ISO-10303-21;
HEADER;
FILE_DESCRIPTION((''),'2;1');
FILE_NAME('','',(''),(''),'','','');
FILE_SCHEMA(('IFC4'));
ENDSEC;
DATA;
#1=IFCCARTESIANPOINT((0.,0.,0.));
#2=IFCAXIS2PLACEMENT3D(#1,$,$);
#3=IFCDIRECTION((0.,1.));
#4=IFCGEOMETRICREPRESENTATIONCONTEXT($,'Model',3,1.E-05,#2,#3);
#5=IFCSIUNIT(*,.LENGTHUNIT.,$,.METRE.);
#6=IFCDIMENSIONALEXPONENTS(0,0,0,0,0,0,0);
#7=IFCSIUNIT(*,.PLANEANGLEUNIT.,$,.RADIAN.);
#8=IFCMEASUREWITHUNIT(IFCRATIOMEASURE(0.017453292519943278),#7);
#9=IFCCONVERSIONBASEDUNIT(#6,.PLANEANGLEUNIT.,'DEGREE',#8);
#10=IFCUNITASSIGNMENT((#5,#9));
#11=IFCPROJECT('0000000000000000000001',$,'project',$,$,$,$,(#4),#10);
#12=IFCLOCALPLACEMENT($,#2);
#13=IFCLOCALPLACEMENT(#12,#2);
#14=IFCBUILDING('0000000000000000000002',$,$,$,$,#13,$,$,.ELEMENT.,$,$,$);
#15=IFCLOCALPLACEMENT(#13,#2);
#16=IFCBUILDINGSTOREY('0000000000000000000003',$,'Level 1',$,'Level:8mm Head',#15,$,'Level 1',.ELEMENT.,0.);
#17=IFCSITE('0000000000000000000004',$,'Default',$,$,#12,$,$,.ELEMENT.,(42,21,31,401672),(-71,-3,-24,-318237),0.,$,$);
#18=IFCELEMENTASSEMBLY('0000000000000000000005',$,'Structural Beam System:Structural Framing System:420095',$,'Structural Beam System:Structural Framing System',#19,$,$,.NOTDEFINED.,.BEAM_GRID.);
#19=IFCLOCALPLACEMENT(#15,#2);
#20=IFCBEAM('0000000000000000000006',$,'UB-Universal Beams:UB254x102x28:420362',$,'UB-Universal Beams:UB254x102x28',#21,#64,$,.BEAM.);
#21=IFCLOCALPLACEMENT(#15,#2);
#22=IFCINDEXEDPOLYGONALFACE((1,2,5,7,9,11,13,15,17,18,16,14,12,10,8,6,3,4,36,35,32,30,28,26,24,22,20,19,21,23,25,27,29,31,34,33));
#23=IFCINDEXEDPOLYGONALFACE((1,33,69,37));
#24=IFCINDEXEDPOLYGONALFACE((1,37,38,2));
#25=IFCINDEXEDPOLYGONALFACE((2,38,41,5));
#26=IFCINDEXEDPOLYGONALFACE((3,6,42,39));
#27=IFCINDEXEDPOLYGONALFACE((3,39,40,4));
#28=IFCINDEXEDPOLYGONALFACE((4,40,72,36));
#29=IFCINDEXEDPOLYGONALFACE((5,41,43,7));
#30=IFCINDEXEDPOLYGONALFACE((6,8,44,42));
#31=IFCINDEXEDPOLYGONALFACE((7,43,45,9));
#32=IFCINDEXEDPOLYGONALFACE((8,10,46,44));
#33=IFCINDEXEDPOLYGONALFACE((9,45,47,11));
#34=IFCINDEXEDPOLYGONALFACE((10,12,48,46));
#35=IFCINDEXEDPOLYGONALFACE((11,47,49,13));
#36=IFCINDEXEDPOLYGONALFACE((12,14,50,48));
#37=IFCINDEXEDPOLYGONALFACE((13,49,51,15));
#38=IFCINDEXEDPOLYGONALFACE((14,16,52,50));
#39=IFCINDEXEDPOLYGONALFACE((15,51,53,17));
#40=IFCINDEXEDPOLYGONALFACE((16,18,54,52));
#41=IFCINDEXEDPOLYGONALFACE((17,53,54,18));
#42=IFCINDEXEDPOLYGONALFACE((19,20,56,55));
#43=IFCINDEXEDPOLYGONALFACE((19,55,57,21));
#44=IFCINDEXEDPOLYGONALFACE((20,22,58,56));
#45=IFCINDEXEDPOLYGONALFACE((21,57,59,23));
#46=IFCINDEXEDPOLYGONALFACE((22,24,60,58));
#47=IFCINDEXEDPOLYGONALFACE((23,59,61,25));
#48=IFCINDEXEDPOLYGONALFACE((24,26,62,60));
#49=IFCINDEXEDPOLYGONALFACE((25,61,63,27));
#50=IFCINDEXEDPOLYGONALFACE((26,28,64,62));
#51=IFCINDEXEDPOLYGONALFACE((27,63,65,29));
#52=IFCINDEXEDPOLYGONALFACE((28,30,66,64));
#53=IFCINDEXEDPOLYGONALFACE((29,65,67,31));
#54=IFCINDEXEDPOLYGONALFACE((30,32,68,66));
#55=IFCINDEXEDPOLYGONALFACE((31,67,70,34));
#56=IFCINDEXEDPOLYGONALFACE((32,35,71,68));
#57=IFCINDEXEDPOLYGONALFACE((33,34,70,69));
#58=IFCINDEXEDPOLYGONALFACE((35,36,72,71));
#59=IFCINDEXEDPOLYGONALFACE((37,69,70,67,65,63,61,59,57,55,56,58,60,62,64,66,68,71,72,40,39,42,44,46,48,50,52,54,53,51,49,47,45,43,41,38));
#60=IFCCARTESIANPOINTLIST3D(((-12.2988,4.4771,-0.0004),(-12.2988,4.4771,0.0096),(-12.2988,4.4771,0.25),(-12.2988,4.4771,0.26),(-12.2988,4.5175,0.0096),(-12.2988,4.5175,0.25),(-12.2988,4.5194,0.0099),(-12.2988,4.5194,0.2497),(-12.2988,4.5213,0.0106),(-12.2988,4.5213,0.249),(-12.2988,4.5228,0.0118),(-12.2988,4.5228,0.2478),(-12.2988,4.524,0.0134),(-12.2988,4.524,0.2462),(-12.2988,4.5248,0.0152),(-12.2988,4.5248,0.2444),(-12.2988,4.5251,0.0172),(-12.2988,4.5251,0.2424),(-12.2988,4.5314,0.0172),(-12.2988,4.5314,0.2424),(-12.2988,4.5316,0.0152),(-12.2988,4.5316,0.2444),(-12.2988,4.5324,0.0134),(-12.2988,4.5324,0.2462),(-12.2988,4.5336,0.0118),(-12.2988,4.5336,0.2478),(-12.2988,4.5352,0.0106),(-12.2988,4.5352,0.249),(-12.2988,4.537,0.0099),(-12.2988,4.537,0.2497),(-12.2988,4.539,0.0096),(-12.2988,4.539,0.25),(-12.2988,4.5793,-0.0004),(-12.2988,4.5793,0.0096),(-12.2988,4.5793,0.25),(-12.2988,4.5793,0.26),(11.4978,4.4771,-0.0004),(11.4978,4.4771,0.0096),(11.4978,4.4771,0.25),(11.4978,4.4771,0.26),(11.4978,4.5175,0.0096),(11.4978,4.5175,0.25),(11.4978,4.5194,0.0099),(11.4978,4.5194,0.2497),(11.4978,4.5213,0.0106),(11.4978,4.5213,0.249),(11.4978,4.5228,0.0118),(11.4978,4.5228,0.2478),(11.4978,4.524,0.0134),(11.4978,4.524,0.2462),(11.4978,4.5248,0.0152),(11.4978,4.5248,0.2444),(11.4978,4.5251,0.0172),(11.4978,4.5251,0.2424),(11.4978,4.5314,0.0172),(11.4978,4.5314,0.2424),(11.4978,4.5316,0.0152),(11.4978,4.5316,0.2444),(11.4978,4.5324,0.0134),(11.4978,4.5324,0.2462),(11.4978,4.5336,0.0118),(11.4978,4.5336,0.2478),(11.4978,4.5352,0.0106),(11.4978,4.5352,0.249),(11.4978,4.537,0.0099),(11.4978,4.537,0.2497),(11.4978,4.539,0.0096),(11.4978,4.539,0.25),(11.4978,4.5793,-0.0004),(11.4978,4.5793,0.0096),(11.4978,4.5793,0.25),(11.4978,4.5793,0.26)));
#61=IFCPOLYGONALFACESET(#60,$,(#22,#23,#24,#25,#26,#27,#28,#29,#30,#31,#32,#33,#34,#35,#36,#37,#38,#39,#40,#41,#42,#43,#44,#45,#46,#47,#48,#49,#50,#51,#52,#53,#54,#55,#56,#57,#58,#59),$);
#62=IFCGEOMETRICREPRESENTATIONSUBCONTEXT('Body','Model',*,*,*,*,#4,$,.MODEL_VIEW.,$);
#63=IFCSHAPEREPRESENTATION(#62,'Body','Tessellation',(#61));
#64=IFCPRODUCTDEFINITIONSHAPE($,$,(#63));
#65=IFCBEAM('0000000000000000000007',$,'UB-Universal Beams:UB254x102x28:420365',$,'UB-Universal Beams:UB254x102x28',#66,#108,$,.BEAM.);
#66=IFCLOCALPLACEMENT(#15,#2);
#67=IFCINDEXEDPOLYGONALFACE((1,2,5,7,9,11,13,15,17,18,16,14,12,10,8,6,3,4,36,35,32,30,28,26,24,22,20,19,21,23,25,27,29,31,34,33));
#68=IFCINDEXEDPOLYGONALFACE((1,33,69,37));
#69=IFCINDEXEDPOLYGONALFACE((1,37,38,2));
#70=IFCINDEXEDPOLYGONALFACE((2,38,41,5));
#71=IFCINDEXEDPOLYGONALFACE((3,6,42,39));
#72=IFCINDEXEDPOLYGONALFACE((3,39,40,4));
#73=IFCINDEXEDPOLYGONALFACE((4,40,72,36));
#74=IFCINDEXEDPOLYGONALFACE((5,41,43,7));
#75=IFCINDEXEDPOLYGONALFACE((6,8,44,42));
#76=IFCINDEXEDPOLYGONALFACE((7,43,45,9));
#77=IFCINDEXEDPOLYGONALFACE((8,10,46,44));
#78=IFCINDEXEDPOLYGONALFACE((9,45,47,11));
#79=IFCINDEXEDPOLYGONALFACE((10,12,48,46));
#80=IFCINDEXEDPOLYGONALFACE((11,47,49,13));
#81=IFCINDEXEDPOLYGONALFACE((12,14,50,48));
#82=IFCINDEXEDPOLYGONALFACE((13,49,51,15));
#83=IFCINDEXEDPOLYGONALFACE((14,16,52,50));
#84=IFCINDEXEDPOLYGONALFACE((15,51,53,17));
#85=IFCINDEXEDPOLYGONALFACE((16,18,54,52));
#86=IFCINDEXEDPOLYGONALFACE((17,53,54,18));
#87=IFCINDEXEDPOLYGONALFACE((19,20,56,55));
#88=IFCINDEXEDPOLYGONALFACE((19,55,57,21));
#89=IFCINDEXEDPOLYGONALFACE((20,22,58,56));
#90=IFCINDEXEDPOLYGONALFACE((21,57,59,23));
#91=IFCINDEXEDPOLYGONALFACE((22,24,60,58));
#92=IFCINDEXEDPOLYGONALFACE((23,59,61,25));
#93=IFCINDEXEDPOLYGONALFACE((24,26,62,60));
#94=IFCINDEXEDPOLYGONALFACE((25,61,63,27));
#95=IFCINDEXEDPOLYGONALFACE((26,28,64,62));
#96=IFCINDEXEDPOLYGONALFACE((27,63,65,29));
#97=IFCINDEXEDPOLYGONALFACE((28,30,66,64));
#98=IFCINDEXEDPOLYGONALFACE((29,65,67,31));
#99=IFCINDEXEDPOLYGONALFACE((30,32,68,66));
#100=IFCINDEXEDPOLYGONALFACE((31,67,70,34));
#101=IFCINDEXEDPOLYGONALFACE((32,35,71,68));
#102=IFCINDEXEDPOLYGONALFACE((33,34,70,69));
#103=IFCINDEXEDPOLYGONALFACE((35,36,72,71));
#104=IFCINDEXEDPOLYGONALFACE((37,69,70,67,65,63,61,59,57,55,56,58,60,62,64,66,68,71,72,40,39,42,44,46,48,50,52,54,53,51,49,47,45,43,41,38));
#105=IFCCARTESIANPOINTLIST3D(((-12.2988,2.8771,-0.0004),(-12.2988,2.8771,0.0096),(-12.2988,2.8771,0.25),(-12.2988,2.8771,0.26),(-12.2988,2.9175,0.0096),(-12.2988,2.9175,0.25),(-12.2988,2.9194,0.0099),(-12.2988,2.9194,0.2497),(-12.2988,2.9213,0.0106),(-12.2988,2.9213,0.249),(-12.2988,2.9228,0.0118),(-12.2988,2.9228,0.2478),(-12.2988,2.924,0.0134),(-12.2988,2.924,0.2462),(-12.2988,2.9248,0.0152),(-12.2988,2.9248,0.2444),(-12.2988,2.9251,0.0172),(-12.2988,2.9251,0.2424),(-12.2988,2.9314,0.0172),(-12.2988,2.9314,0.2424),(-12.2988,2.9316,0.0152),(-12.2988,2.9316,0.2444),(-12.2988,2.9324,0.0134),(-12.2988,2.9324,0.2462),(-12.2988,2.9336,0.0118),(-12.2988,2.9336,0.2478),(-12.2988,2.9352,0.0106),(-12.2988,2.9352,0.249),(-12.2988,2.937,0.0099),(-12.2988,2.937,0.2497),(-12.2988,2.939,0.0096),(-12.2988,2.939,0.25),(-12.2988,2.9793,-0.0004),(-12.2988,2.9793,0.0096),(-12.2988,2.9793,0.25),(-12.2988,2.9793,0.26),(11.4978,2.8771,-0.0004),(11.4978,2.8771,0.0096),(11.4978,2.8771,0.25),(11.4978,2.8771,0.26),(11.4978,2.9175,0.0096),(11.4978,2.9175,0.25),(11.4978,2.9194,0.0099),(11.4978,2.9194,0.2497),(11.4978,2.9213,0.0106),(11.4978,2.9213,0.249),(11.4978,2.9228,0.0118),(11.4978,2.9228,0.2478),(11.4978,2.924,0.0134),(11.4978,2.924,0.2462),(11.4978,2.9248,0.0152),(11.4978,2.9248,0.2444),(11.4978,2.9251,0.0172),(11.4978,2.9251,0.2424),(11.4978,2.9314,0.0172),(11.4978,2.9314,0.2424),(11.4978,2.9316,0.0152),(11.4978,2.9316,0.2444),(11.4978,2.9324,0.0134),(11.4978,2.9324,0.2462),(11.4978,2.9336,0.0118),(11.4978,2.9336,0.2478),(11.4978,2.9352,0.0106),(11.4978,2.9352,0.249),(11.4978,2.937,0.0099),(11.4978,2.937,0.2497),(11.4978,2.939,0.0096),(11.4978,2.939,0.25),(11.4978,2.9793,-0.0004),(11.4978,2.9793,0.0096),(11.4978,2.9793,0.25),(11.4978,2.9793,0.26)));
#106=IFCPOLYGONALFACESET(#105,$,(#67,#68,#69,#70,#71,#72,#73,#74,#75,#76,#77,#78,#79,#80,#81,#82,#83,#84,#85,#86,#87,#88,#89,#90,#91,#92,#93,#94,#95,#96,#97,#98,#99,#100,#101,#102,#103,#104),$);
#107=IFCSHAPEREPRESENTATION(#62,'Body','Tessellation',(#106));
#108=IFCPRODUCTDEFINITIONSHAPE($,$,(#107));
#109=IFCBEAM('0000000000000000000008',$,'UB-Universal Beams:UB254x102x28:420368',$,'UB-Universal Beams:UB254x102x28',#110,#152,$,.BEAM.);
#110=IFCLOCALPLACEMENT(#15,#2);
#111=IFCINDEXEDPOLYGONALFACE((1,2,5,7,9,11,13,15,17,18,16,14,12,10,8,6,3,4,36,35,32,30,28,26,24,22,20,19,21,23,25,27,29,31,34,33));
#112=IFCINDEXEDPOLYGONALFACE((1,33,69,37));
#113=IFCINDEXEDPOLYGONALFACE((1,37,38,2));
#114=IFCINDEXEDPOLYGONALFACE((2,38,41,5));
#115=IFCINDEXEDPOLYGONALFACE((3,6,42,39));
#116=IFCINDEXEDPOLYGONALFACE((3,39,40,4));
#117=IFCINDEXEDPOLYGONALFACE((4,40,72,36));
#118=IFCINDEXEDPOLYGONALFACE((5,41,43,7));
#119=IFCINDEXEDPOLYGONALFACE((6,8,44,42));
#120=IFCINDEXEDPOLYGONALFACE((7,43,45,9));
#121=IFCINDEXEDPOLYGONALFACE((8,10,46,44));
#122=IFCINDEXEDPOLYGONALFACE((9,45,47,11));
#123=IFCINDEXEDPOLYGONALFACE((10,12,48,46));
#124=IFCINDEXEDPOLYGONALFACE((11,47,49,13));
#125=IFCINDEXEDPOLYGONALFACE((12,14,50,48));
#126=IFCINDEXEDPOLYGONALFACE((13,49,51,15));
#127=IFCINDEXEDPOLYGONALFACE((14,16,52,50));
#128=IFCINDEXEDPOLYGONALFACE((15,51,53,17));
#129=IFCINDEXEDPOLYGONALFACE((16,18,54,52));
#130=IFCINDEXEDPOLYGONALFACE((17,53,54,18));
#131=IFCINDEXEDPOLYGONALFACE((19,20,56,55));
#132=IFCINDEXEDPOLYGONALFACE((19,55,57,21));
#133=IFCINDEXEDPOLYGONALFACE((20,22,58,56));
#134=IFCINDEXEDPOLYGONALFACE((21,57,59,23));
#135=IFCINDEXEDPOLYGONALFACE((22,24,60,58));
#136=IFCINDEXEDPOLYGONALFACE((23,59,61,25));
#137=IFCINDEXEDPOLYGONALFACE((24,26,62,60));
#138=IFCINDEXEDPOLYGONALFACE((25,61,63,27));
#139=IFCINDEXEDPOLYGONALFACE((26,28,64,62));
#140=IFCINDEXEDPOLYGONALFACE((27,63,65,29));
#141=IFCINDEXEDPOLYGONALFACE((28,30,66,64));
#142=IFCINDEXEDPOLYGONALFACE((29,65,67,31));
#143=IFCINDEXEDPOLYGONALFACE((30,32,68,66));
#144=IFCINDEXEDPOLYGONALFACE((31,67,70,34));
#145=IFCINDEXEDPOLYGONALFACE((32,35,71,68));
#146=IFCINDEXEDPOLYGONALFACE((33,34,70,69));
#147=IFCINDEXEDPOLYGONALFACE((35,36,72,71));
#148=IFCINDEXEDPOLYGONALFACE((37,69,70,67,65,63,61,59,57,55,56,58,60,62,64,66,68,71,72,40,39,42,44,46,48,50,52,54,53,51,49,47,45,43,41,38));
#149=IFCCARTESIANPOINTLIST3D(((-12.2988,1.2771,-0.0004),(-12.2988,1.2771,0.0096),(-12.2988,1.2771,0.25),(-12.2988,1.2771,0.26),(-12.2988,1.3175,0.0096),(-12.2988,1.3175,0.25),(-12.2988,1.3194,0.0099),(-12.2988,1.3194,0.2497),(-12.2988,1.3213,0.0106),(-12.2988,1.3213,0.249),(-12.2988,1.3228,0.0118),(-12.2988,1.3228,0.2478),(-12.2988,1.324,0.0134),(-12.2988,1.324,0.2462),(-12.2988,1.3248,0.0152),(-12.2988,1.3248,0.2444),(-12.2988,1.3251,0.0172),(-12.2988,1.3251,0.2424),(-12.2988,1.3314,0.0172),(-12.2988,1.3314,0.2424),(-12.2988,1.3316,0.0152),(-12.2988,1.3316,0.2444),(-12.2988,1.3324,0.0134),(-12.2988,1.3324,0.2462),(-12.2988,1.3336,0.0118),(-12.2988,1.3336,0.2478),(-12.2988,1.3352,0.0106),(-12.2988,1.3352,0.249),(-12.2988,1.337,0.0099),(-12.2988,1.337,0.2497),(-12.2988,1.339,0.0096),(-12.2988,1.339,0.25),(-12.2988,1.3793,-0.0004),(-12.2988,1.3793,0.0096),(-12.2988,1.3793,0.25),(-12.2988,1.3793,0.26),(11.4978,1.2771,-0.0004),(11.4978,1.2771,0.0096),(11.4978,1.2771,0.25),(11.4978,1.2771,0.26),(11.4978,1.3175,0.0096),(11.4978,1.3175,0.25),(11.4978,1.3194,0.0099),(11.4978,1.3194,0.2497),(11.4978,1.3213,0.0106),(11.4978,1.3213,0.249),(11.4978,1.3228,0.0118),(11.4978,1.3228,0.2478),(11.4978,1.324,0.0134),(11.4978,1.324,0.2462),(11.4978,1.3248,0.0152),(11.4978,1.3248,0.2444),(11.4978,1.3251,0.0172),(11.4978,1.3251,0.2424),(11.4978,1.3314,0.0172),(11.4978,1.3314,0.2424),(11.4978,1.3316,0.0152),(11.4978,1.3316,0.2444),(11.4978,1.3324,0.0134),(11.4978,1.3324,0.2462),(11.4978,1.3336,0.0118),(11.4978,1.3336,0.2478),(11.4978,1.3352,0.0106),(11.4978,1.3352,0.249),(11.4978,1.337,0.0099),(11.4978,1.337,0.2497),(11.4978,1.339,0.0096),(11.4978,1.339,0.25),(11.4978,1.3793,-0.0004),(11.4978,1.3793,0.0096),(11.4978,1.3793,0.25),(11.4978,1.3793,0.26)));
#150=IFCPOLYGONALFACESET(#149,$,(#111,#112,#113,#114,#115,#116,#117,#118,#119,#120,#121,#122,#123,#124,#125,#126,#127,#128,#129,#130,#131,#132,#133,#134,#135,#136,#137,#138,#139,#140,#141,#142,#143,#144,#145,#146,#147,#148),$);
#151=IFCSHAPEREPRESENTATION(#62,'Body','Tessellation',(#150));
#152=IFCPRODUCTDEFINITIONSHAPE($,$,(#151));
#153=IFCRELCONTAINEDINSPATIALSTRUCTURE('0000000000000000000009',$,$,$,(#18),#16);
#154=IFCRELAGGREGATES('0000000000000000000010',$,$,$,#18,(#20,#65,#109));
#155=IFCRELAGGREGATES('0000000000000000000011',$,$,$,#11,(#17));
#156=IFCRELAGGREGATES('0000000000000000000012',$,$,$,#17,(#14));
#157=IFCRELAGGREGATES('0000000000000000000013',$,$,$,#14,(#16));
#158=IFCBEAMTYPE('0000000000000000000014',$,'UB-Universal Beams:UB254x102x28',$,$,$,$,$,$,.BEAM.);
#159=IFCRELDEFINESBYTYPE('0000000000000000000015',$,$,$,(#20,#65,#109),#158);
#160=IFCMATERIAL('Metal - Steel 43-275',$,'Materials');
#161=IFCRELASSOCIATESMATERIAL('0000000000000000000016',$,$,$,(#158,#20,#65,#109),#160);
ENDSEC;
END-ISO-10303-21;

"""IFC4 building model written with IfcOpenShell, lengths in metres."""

from ifc_helpers import new_model, entity, si_unit, converted_unit, direction, frame, origin, place, context, subcontext, project, spatial, line, arc, indexed_curve, outline, extrude, source, transform, mapped, material, type_object, type_shapes, element, aggregate, save


model = new_model("IFC4")

# Units and contexts
model_context = context("Model", 3, precision=1e-05, world=origin(), true_north=direction((0.0, 1.0)))
body_context = subcontext(model_context, "Body", "Model", "MODEL_VIEW")
ifc_project = project(units=[si_unit("LENGTHUNIT", "METRE"), converted_unit("PLANEANGLEUNIT", "DEGREE", entity("IfcRatioMeasure", 0.017453292519943278), si_unit("PLANEANGLEUNIT", "RADIAN"), dimensions=[0, 0, 0, 0, 0, 0, 0])], contexts=[model_context])

# Site, building, storey
site_placement = place(None, origin())
site = spatial("IfcSite", under=ifc_project, at=site_placement, Name="Default", CompositionType="ELEMENT", RefLatitude=(42, 21, 31, 401672), RefLongitude=(-71, -3, -24, -318237), RefElevation=0.0)
building_placement = place(site_placement, origin())
building = spatial("IfcBuilding", under=site, at=building_placement, CompositionType="ELEMENT")
storey_placement = place(building_placement, origin())
storey = spatial("IfcBuildingStorey", under=building, at=storey_placement, Name="Level 1", ObjectType="Level:8mm Head", LongName="Level 1", CompositionType="ELEMENT", Elevation=0.0)

# Shared definitions
ifc_material_1 = material(Name="Metal - Steel 43-275", Category="Materials")

# Element assembly, beams
assembly_placement = place(storey_placement, origin())
assembly = element("IfcElementAssembly", 1, at=assembly_placement, inside=storey, Name="Structural Beam System:Structural Framing System:420095", ObjectType="Structural Beam System:Structural Framing System", AssemblyPlace="NOTDEFINED", PredefinedType="BEAM_GRID")
beam_type_1 = type_object("IfcBeamType", Name="UB-Universal Beams:UB254x102x28", PredefinedType="BEAM", material=ifc_material_1)
shared_shape_1 = source(origin(), body_context, "Body", "SweptSolid", [
    extrude(outline(indexed_curve([(-0.1302, -0.0511), (-0.1202, -0.0511), (-0.1202, -0.0107), (-0.118, -0.0054), (-0.1126, -0.0031), (0.1126, -0.0031), (0.118, -0.0054), (0.1202, -0.0107), (0.1202, -0.0511), (0.1302, -0.0511), (0.1302, 0.0511), (0.1202, 0.0511), (0.1202, 0.0108), (0.118, 0.0054), (0.1126, 0.0032), (-0.1126, 0.0032), (-0.118, 0.0054), (-0.1202, 0.0108), (-0.1202, 0.0511), (-0.1302, 0.0511)], segments=[line(1, 2, 3), arc(3, 4, 5), line(5, 6), arc(6, 7, 8), line(8, 9, 10, 11, 12, 13), arc(13, 14, 15), line(15, 16), arc(16, 17, 18), line(18, 19, 20, 1)], self_intersect=False)), frame((-11.8983, 0.0, 0.0), z_axis=(1.0, 0.0, 0.0), x_axis=(0.0, 0.0, -1.0)), (0.0, 0.0, 1.0), 23.7966),
])
type_shapes(beam_type_1, [shared_shape_1])
beam_1_placement = place(assembly_placement, frame((-0.4005, 4.5282, 0.1298)))
beam_1 = element("IfcBeam", 2, at=beam_1_placement, type_object=beam_type_1, material=ifc_material_1, Name="UB-Universal Beams:UB254x102x28:420362", ObjectType="UB-Universal Beams:UB254x102x28", PredefinedType="BEAM", context=body_context, shape_type="MappedRepresentation", body=[
    mapped(shared_shape_1, transform((0.0, 0.0, 0.0), scale=1.0)),
])
beam_2_placement = place(assembly_placement, frame((-0.4005, 2.9282, 0.1298)))
beam_2 = element("IfcBeam", 3, at=beam_2_placement, type_object=beam_type_1, material=ifc_material_1, Name="UB-Universal Beams:UB254x102x28:420365", ObjectType="UB-Universal Beams:UB254x102x28", PredefinedType="BEAM", context=body_context, shape_type="MappedRepresentation", body=[
    mapped(shared_shape_1, transform((0.0, 0.0, 0.0), scale=1.0)),
])
beam_3_placement = place(assembly_placement, frame((-0.4005, 1.3282, 0.1298)))
beam_3 = element("IfcBeam", 4, at=beam_3_placement, type_object=beam_type_1, material=ifc_material_1, Name="UB-Universal Beams:UB254x102x28:420368", ObjectType="UB-Universal Beams:UB254x102x28", PredefinedType="BEAM", context=body_context, shape_type="MappedRepresentation", body=[
    mapped(shared_shape_1, transform((0.0, 0.0, 0.0), scale=1.0)),
])
aggregate(assembly, [beam_1, beam_2, beam_3])

save(model, "model.ifc")
